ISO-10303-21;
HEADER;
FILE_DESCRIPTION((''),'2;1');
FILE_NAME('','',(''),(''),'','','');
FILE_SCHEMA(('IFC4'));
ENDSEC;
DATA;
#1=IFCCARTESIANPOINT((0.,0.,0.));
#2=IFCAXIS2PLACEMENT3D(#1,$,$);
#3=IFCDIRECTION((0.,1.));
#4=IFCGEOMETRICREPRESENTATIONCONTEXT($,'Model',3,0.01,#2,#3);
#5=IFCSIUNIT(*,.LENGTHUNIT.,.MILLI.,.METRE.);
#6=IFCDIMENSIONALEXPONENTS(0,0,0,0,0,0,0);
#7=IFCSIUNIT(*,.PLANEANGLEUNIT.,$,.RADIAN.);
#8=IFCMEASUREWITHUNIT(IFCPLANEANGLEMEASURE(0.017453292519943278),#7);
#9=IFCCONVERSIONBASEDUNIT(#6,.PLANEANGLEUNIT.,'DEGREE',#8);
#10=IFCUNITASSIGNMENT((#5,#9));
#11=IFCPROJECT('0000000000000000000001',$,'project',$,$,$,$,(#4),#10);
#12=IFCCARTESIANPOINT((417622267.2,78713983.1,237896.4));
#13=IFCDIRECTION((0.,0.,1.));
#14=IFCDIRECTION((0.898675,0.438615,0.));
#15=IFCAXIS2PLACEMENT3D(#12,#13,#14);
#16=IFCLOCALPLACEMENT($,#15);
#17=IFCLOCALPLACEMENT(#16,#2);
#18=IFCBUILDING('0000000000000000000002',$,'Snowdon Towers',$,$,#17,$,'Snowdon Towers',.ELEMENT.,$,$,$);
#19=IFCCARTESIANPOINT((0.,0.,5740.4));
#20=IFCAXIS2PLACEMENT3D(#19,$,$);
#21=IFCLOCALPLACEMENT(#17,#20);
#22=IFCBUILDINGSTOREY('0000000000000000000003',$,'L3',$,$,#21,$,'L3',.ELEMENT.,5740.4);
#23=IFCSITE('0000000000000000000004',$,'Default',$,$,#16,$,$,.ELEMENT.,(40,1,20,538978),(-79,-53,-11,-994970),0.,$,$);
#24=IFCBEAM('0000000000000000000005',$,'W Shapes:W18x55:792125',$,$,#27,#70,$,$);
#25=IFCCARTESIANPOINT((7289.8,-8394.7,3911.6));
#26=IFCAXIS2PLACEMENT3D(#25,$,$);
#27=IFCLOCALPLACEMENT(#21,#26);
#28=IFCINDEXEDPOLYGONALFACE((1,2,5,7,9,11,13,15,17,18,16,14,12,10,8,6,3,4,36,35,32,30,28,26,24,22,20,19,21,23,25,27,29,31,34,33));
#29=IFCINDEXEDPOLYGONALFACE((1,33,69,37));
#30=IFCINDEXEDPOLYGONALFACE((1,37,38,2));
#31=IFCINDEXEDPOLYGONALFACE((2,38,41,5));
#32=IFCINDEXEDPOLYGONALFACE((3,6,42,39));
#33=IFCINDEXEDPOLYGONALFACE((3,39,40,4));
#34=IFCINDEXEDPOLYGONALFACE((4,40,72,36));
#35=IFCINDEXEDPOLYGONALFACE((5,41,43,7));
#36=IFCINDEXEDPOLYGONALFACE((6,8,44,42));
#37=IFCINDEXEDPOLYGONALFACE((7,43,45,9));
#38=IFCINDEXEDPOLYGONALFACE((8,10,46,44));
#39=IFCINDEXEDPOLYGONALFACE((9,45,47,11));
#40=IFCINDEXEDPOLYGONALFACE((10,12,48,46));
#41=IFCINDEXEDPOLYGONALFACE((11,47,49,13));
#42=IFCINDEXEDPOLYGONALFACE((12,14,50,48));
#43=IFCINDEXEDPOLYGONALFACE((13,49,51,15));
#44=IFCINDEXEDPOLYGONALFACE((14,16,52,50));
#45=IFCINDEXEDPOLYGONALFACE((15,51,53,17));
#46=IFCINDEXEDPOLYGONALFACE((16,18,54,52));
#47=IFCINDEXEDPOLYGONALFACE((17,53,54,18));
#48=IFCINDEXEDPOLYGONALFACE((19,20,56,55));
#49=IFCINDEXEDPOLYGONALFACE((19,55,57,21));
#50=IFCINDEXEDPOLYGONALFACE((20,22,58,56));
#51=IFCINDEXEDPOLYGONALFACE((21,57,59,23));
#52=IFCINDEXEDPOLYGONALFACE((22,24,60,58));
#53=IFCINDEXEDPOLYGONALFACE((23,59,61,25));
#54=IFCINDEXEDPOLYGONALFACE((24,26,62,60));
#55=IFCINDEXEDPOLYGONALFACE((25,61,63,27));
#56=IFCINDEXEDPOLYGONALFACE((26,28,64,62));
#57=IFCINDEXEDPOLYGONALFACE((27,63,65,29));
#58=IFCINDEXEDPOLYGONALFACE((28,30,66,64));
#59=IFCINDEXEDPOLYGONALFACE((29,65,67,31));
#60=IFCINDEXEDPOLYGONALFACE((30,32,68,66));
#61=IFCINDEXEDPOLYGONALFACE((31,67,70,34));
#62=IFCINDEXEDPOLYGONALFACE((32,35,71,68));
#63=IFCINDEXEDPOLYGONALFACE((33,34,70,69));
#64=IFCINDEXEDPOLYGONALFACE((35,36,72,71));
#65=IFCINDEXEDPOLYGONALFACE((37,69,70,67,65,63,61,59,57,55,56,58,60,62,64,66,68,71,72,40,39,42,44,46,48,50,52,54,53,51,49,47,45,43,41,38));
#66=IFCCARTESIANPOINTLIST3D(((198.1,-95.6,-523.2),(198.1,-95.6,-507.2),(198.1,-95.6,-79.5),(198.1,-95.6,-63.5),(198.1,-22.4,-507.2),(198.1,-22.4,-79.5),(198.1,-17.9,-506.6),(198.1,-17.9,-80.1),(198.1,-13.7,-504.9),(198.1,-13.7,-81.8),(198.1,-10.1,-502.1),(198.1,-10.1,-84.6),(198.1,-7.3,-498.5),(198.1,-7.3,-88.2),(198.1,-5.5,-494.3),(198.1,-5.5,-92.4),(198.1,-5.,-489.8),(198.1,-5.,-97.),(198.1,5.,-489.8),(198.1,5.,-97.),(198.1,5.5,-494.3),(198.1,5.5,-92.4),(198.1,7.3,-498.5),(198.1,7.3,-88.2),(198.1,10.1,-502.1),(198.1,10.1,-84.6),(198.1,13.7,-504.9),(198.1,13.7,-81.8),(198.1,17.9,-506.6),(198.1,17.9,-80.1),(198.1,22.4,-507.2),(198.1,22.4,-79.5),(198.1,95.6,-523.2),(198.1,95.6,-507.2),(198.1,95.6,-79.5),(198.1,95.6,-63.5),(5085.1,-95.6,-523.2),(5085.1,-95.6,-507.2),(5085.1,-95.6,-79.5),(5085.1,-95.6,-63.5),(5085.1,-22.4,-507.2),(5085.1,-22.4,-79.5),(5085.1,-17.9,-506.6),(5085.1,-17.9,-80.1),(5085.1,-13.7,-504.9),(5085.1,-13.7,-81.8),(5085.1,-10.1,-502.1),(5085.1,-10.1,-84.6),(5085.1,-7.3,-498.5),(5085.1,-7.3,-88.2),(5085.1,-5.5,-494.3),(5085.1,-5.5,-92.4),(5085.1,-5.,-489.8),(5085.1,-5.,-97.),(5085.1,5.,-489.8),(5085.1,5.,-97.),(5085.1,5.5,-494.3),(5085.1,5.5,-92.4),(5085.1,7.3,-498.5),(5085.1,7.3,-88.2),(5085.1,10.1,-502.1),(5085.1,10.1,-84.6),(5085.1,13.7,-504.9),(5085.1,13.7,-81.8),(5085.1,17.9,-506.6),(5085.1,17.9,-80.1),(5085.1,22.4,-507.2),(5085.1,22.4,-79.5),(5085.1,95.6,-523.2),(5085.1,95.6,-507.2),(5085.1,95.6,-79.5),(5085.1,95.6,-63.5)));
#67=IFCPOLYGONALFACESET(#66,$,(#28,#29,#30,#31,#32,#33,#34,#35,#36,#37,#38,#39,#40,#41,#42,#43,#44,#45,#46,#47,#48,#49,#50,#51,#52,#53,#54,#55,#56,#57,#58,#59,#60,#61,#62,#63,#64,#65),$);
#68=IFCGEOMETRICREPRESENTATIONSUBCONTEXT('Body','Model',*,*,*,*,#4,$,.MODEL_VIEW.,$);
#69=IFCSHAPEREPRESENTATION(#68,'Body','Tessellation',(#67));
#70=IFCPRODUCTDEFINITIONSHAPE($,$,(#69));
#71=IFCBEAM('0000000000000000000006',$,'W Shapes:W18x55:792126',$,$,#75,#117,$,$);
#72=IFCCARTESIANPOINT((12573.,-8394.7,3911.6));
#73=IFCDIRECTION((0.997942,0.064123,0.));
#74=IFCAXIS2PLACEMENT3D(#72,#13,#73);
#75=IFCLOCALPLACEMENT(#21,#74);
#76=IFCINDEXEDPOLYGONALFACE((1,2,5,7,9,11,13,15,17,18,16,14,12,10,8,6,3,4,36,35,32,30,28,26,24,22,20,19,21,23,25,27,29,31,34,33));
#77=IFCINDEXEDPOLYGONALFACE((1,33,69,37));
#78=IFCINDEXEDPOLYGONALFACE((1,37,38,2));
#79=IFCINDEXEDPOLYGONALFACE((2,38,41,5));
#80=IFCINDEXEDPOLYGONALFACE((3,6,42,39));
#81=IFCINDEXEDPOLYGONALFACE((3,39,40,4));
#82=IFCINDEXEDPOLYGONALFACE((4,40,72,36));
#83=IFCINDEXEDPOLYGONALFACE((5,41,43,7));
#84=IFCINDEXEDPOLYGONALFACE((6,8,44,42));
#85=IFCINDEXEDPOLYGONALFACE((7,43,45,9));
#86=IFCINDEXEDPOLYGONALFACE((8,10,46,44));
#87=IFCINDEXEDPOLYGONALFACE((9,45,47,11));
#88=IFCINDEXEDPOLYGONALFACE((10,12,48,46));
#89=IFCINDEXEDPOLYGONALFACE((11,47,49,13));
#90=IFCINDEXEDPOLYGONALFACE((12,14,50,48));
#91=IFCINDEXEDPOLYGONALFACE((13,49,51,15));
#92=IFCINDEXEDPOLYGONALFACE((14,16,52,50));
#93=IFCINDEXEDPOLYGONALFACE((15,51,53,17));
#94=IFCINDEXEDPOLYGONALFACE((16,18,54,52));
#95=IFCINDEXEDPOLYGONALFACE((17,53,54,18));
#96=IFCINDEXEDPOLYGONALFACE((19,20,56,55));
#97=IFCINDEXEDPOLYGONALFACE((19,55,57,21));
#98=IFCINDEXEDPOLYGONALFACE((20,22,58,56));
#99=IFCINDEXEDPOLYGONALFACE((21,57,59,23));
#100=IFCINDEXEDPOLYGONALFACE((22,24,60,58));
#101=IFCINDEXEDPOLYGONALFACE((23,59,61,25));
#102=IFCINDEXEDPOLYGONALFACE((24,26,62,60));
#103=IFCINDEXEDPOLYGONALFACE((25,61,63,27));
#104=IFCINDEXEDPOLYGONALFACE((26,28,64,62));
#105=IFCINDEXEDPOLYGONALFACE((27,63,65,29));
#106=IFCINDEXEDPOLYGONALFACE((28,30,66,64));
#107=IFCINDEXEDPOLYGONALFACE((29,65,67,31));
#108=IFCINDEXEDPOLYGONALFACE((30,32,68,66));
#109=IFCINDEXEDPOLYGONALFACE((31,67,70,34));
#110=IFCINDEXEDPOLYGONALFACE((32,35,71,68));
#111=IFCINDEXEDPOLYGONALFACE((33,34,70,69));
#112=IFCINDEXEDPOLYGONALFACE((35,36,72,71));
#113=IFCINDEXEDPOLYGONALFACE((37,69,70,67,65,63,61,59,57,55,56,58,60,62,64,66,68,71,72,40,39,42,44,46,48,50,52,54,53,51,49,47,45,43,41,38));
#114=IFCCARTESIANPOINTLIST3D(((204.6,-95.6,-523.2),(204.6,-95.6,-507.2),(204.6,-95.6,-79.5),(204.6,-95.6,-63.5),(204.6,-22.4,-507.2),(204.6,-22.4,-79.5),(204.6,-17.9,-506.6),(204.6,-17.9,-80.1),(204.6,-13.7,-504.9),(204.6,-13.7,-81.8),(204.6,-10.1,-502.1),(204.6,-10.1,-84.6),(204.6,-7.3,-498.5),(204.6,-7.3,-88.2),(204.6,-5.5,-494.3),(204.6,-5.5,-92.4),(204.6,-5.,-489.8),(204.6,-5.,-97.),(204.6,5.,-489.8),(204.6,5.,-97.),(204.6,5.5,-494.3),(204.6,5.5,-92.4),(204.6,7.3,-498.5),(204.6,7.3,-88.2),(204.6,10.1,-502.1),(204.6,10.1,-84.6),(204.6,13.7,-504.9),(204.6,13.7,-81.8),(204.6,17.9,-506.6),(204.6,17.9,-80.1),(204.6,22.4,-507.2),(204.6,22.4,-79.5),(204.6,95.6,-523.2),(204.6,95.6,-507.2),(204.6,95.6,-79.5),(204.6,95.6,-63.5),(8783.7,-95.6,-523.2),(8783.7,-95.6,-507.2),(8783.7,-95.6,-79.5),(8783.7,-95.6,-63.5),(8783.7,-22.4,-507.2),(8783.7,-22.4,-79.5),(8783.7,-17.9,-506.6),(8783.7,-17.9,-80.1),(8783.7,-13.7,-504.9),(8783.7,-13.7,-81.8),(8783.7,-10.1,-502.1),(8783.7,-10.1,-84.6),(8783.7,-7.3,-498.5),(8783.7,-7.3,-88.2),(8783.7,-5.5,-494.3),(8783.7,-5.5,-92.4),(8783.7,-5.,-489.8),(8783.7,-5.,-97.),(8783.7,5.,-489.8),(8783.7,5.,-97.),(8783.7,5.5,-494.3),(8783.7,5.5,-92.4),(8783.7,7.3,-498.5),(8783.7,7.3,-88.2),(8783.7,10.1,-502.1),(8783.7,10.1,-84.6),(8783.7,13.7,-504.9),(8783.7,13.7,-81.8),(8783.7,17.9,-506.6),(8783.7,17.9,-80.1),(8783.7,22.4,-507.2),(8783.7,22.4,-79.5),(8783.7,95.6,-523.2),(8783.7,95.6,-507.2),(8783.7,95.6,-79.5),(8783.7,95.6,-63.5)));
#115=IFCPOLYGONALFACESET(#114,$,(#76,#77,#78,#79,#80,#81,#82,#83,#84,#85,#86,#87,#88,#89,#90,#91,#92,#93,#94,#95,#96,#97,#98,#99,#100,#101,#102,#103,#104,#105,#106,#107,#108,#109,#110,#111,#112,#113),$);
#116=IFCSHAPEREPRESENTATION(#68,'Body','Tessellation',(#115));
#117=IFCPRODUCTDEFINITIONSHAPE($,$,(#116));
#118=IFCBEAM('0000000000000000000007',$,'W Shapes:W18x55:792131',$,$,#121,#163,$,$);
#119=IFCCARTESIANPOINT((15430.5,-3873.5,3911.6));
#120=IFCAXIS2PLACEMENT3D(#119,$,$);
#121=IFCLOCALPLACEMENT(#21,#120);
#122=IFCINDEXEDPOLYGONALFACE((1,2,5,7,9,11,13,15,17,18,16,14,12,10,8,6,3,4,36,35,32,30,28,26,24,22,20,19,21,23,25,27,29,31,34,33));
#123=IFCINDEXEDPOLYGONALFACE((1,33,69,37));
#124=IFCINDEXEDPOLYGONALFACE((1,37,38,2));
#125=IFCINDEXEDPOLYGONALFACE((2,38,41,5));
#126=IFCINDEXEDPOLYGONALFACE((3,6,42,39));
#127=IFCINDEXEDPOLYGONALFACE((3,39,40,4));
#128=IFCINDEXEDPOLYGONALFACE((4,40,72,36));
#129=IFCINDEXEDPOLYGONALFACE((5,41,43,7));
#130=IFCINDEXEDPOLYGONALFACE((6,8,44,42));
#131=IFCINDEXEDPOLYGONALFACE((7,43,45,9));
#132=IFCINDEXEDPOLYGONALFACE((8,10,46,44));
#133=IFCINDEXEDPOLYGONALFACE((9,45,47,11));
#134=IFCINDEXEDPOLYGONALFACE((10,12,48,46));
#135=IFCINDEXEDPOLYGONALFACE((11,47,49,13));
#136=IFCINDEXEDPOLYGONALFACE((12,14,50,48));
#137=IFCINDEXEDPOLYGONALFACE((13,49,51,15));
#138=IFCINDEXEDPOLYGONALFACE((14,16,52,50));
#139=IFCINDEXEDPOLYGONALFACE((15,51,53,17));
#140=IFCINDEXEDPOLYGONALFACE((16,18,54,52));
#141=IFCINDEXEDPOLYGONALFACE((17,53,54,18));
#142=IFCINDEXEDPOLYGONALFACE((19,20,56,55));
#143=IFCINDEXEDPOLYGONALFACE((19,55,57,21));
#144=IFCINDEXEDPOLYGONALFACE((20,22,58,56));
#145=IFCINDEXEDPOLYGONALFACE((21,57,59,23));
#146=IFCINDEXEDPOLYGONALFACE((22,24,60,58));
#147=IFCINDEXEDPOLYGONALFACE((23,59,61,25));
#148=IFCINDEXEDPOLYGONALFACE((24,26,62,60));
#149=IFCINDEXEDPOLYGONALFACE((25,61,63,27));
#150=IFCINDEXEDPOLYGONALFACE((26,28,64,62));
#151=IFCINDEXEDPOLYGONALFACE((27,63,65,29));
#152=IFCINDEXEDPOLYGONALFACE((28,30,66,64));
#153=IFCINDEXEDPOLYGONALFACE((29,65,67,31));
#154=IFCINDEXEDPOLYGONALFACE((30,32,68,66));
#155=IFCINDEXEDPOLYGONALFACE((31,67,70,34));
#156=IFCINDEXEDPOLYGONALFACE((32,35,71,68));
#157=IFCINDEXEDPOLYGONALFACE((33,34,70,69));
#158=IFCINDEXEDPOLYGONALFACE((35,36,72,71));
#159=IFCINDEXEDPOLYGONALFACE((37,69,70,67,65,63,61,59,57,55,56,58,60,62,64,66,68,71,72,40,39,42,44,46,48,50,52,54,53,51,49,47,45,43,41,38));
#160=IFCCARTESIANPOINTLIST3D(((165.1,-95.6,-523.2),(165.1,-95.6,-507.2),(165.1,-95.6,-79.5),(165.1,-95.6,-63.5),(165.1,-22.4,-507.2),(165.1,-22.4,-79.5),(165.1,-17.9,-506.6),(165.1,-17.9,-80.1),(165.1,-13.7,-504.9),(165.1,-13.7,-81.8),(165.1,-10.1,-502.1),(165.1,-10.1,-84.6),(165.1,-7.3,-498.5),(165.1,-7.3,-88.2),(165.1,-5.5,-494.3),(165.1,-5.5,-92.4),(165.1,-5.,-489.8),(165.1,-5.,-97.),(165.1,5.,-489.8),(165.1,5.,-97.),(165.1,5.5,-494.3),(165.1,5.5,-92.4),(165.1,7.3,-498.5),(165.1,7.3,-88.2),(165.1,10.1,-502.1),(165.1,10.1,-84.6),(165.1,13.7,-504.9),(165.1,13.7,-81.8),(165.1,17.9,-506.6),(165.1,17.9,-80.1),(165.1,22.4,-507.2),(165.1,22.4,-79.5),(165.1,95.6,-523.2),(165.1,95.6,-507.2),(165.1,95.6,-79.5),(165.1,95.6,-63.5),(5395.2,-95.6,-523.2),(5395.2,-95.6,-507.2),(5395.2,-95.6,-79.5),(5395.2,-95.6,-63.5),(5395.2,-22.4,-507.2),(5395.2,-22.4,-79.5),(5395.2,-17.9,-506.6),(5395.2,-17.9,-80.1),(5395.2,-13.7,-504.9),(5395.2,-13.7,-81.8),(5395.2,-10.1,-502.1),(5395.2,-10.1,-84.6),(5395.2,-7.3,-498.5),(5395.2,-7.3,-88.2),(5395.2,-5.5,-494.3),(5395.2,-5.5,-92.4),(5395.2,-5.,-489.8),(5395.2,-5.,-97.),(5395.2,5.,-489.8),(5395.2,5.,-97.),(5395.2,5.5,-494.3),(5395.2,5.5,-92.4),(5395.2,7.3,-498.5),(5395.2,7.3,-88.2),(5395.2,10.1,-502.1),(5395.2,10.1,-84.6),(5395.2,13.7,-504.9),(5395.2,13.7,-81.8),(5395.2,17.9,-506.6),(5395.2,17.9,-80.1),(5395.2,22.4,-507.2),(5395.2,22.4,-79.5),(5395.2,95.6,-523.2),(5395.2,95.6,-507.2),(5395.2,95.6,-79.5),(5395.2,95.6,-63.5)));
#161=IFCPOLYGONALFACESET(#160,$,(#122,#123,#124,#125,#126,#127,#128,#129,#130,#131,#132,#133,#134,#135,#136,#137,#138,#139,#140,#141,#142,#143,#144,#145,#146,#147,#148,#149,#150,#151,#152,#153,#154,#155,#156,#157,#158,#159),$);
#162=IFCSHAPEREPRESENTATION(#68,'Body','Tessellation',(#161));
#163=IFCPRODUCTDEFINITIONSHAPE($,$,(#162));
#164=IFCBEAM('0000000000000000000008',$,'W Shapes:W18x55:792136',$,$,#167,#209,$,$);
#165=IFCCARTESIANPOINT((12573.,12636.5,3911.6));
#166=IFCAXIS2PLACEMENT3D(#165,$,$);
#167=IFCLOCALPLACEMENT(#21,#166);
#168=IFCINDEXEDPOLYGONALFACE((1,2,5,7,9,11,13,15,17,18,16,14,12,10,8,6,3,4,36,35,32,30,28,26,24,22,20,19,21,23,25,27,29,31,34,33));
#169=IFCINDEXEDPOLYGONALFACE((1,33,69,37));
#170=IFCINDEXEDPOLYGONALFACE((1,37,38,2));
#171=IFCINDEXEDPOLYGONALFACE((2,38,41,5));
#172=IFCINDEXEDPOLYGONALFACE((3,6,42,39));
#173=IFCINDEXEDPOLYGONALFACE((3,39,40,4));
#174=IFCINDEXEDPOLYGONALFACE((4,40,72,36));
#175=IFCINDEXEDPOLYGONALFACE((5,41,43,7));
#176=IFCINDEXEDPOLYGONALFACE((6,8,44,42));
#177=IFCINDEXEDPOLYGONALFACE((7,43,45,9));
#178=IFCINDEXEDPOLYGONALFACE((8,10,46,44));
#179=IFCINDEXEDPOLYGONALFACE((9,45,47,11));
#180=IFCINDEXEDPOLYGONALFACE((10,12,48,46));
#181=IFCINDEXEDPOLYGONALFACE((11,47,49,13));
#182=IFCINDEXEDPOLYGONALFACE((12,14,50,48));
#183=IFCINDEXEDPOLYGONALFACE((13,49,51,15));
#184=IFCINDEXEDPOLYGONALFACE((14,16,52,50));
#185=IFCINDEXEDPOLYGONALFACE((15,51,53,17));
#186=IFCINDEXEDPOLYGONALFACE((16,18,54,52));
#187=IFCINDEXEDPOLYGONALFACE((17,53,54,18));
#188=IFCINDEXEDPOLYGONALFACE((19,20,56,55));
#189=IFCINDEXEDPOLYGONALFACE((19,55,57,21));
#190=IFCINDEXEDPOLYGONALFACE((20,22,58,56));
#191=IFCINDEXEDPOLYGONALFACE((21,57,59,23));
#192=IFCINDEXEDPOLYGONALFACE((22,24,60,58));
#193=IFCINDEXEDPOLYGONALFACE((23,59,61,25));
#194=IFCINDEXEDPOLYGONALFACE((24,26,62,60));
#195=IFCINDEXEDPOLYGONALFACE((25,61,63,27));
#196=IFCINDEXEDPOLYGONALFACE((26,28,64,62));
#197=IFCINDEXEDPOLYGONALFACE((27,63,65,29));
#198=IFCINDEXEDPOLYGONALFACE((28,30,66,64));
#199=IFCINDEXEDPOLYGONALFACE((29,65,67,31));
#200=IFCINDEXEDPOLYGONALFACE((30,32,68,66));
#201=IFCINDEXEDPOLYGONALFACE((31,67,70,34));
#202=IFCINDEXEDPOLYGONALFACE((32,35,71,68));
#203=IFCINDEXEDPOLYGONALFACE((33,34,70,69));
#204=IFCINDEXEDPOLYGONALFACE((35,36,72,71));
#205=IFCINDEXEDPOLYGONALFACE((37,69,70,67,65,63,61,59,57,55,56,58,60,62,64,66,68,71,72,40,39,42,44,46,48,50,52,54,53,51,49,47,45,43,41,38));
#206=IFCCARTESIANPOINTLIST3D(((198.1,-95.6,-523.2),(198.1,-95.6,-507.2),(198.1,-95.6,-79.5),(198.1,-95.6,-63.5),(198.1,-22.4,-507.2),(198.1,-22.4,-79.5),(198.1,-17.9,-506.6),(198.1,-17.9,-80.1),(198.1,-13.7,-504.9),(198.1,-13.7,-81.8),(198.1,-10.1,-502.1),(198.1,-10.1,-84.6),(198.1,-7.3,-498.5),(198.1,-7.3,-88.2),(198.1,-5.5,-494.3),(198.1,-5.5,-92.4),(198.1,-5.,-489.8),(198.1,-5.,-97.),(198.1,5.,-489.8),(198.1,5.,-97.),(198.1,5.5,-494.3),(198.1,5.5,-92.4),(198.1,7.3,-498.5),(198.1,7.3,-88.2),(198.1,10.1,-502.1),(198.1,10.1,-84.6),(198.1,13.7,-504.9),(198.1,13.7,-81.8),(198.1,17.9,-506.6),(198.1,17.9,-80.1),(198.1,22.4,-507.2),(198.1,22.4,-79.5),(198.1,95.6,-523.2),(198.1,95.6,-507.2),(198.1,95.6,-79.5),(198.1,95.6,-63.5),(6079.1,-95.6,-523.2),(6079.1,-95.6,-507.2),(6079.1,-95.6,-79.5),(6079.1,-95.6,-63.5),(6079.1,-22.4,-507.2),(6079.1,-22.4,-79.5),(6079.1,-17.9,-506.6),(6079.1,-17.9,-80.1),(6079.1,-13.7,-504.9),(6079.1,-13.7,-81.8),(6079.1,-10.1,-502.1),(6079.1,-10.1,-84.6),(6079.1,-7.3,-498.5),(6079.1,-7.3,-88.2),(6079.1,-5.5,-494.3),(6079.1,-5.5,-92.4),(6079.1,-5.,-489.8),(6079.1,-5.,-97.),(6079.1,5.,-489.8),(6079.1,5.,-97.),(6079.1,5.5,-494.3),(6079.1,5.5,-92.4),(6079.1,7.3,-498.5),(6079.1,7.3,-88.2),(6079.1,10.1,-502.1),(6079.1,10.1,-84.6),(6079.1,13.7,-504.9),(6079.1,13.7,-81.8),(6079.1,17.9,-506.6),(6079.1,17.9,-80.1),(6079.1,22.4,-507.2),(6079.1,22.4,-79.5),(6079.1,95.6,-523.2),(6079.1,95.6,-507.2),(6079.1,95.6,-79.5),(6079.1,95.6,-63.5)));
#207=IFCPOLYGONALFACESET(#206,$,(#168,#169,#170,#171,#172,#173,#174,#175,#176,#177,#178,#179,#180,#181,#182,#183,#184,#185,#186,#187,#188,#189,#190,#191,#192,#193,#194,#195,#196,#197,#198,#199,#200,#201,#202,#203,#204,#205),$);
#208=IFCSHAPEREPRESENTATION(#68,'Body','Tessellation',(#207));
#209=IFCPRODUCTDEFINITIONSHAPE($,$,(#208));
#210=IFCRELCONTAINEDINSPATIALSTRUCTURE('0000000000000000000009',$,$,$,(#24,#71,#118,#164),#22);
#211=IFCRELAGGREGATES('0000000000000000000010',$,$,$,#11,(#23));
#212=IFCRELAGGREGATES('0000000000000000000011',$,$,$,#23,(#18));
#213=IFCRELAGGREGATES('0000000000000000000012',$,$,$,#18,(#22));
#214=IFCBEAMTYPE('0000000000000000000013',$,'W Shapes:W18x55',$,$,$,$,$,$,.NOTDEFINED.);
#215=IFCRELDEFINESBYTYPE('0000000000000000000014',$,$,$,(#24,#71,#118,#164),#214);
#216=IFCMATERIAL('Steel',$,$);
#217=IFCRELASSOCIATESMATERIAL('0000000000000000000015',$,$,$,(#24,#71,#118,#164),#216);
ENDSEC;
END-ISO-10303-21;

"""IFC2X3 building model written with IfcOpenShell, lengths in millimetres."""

from ifc_helpers import new_model, entity, si_unit, converted_unit, direction, frame, frame_2d, origin, place, context, subcontext, project, spatial, i_section, extrude, material, type_object, element, save


model = new_model("IFC2X3")

# Units and contexts
model_context = context("Model", 3, precision=0.01, world=origin(), true_north=direction((0.0, 1.0)))
body_context = subcontext(model_context, "Body", "Model", "MODEL_VIEW")
ifc_project = project(units=[si_unit("LENGTHUNIT", "METRE", prefix="MILLI"), converted_unit("PLANEANGLEUNIT", "DEGREE", entity("IfcPlaneAngleMeasure", 0.017453292519943278), si_unit("PLANEANGLEUNIT", "RADIAN"), dimensions=[0, 0, 0, 0, 0, 0, 0])], contexts=[model_context])

# Site, building, storey
site_placement = place(None, frame((417622267.2, 78713983.1, 237896.4), z_axis=(0.0, 0.0, 1.0), x_axis=(0.898675, 0.438615, 0.0)))
site = spatial("IfcSite", under=ifc_project, at=site_placement, Name="Default", CompositionType="ELEMENT", RefLatitude=(40, 1, 20, 538978), RefLongitude=(-79, -53, -11, -994970), RefElevation=0.0)
building_placement = place(site_placement, origin())
building = spatial("IfcBuilding", under=site, at=building_placement, Name="Snowdon Towers", LongName="Snowdon Towers", CompositionType="ELEMENT")
storey_placement = place(building_placement, frame((0.0, 0.0, 5740.4)))
storey = spatial("IfcBuildingStorey", under=building, at=storey_placement, Name="L3", LongName="L3", CompositionType="ELEMENT", Elevation=5740.4)

# Shared definitions
ifc_material_1 = material(Name="Steel")

# Beams
beam_type_1 = type_object("IfcBeamType", Name="W Shapes:W18x55", PredefinedType="NOTDEFINED")
beam_1_placement = place(storey_placement, frame((7289.8, -8394.7, 3911.6)))
element("IfcBeam", 1, at=beam_1_placement, inside=storey, type_object=beam_type_1, material=ifc_material_1, Name="W Shapes:W18x55:792125", context=body_context, shape_type="SweptSolid", body=[
    extrude(i_section(OverallWidth=191.3, OverallDepth=459.7, WebThickness=9.9, FlangeThickness=16.0, FilletRadius=17.5, at=frame_2d((0.0, 0.0), x_axis=(0.0, 1.0))), frame((198.1, 0.0, -293.4), z_axis=(1.0, 0.0, 0.0), x_axis=(0.0, 0.0, -1.0)), (0.0, 0.0, 1.0), 4887.0),
])
beam_2_placement = place(storey_placement, frame((12573.0, -8394.7, 3911.6), z_axis=(0.0, 0.0, 1.0), x_axis=(0.997942, 0.064123, 0.0)))
element("IfcBeam", 2, at=beam_2_placement, inside=storey, type_object=beam_type_1, material=ifc_material_1, Name="W Shapes:W18x55:792126", context=body_context, shape_type="SweptSolid", body=[
    extrude(i_section(OverallWidth=191.3, OverallDepth=459.7, WebThickness=9.9, FlangeThickness=16.0, FilletRadius=17.5, at=frame_2d((0.0, 0.0), x_axis=(0.0, 1.0))), frame((204.6, 0.0, -293.4), z_axis=(1.0, 0.0, 0.0), x_axis=(0.0, 0.0, -1.0)), (0.0, 0.0, 1.0), 8579.1),
])
beam_3_placement = place(storey_placement, frame((15430.5, -3873.5, 3911.6)))
element("IfcBeam", 3, at=beam_3_placement, inside=storey, type_object=beam_type_1, material=ifc_material_1, Name="W Shapes:W18x55:792131", context=body_context, shape_type="SweptSolid", body=[
    extrude(i_section(OverallWidth=191.3, OverallDepth=459.7, WebThickness=9.9, FlangeThickness=16.0, FilletRadius=17.5, at=frame_2d((0.0, 0.0), x_axis=(0.0, 1.0))), frame((165.1, 0.0, -293.4), z_axis=(1.0, 0.0, 0.0), x_axis=(0.0, 0.0, -1.0)), (0.0, 0.0, 1.0), 5230.1),
])
beam_4_placement = place(storey_placement, frame((12573.0, 12636.5, 3911.6)))
element("IfcBeam", 4, at=beam_4_placement, inside=storey, type_object=beam_type_1, material=ifc_material_1, Name="W Shapes:W18x55:792136", context=body_context, shape_type="SweptSolid", body=[
    extrude(i_section(OverallWidth=191.3, OverallDepth=459.7, WebThickness=9.9, FlangeThickness=16.0, FilletRadius=17.5, at=frame_2d((0.0, 0.0), x_axis=(0.0, 1.0))), frame((198.1, 0.0, -293.4), z_axis=(1.0, 0.0, 0.0), x_axis=(0.0, 0.0, -1.0)), (0.0, 0.0, 1.0), 5881.0),
])

save(model, "model.ifc")
